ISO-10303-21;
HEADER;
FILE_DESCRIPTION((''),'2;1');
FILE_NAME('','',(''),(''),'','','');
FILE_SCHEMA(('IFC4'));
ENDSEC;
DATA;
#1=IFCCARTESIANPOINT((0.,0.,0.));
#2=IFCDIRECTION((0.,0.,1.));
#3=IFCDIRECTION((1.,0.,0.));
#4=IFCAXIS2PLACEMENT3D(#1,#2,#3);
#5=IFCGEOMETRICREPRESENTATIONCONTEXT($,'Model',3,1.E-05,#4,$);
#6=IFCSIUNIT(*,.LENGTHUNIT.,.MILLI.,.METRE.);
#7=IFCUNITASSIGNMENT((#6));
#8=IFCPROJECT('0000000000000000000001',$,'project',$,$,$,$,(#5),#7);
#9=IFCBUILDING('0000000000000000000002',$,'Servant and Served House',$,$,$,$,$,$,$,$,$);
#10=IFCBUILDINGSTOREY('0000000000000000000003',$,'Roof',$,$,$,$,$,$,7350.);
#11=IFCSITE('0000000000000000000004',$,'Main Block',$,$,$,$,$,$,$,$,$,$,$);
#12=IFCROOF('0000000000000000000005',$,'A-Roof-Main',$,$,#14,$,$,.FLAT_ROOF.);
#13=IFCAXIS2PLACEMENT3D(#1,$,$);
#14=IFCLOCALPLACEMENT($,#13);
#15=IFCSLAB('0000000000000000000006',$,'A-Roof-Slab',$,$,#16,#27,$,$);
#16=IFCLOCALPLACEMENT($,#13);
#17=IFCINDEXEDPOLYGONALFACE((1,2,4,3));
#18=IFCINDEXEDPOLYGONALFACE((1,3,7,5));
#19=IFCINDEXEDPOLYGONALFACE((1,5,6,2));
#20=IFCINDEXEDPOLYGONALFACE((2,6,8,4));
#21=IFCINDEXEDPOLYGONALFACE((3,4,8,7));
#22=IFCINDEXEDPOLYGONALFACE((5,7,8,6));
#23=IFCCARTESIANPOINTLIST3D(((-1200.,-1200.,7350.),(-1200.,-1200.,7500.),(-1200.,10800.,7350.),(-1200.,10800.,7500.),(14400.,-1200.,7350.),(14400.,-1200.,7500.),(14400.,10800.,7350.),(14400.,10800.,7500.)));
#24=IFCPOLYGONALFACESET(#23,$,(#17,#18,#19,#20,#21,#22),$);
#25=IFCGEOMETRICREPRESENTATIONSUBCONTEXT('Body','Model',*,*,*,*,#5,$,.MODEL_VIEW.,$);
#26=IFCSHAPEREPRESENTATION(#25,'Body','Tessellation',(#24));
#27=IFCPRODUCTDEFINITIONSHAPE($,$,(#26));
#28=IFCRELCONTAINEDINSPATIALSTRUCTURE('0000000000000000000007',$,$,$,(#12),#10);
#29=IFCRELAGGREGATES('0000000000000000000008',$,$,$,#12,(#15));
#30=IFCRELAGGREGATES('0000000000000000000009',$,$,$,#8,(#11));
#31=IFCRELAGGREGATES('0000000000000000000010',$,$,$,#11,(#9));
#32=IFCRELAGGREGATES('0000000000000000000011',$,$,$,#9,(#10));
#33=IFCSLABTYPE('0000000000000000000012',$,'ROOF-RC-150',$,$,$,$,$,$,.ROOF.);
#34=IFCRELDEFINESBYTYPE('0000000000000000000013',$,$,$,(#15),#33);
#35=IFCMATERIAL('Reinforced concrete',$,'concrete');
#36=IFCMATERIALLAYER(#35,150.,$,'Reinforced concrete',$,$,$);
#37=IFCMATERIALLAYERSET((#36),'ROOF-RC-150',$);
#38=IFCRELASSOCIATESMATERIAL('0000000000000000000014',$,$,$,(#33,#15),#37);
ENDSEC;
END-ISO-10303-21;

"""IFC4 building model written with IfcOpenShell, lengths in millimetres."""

from ifc_helpers import new_model, si_unit, frame, origin_with_axes, place, context, subcontext, project, spatial, indexed_curve, outline, extrude, material, layer, layer_set, layer_usage, type_object, element, aggregate, save


model = new_model("IFC4")

# Units and contexts
model_context = context("Model", 3, precision=1e-05, world=origin_with_axes())
body_context = subcontext(model_context, "Body", "Model", "MODEL_VIEW")
ifc_project = project(units=[si_unit("LENGTHUNIT", "METRE", prefix="MILLI")], contexts=[model_context])

# Site, building, storey
site = spatial("IfcSite", under=ifc_project, Name="Main Block")
building = spatial("IfcBuilding", under=site, Name="Servant and Served House")
storey = spatial("IfcBuildingStorey", under=building, Name="Roof", Elevation=7350.0)

# Roof, slab
roof = element("IfcRoof", 1, inside=storey, Name="A-Roof-Main", PredefinedType="FLAT_ROOF")
ifc_material = material(Name="Reinforced concrete", Category="concrete")
ifc_layer = layer(ifc_material, 150.0, Name="Reinforced concrete")
ifc_layer_set = layer_set([ifc_layer], Name="ROOF-RC-150")
ifc_layer_usage = layer_usage(ifc_layer_set, "AXIS3", "POSITIVE", 0.0)
slab_type = type_object("IfcSlabType", Name="ROOF-RC-150", PredefinedType="ROOF", material=ifc_layer_set)
slab_placement = place(None, frame((0.0, 0.0, 7350.0), z_axis=(0.0, 0.0, 1.0), x_axis=(1.0, 0.0, 0.0)))
slab = element("IfcSlab", 2, at=slab_placement, type_object=slab_type, material=ifc_layer_usage, Name="A-Roof-Slab", context=body_context, shape_type="SweptSolid", body=[
    extrude(outline(indexed_curve([(-1200.0, -1200.0), (14400.0, -1200.0), (14400.0, 10800.0), (-1200.0, 10800.0)])), None, (0.0, 0.0, 1.0), 150.0),
])
aggregate(roof, [slab])

save(model, "model.ifc")
